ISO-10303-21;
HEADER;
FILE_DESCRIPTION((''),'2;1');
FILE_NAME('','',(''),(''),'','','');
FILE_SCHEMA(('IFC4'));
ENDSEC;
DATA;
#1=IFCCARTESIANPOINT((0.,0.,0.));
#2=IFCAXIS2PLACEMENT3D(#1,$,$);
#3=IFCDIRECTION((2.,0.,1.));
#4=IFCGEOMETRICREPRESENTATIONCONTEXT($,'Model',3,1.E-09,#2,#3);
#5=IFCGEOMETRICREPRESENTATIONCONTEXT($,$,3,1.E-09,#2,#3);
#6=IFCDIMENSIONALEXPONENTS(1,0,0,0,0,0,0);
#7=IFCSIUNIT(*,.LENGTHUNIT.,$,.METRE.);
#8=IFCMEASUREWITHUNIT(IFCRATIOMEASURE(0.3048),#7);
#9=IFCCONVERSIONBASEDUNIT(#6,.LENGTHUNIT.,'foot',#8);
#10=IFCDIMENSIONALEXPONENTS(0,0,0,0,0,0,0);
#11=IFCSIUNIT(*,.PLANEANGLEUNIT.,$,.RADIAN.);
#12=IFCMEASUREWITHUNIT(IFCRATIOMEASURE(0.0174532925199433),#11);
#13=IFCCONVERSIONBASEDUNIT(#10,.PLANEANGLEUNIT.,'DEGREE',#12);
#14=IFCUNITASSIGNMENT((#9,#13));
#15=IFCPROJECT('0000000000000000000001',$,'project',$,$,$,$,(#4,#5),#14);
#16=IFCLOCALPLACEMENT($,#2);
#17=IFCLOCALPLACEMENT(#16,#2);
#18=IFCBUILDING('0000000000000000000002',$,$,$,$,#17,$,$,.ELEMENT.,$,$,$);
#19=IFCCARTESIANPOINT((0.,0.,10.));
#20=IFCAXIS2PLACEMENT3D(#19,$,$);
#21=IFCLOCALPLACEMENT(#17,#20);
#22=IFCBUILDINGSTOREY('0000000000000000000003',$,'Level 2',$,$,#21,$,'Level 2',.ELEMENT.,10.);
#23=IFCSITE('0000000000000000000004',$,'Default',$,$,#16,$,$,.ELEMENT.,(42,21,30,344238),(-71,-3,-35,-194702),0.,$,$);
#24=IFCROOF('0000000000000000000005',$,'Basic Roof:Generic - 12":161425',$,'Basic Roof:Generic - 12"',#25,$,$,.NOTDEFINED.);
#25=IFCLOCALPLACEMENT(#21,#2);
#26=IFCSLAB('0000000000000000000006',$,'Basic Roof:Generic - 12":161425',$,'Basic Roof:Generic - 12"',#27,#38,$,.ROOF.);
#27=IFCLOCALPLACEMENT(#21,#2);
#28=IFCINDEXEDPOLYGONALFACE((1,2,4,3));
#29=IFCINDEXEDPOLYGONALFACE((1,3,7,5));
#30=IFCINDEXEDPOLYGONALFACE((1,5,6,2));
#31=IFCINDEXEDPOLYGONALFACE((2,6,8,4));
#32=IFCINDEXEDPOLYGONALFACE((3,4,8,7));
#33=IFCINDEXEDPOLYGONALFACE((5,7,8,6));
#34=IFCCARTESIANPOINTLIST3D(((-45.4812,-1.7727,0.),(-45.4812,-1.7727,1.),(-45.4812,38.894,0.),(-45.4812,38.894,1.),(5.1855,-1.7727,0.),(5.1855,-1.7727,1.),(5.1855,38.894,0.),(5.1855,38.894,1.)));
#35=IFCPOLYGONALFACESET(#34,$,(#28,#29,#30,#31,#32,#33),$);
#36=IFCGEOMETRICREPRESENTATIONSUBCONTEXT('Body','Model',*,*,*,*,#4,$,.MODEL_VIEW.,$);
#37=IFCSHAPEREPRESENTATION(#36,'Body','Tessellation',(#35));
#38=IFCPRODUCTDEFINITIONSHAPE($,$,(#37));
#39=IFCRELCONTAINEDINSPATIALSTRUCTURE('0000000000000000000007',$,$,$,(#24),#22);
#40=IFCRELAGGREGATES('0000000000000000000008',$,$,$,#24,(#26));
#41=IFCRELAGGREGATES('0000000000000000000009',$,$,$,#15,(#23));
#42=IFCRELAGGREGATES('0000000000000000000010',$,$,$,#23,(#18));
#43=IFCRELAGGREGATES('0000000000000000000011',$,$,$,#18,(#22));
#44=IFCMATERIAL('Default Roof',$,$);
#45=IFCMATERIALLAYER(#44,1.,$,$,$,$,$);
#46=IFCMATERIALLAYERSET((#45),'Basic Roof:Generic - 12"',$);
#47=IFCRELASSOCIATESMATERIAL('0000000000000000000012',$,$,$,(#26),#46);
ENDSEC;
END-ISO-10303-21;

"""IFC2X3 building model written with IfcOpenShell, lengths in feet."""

from ifc_helpers import new_model, entity, si_unit, converted_unit, direction, frame, frame_2d, origin, place, context, subcontext, project, spatial, rectangle, extrude, material, layer, layer_set, element, aggregate, save


model = new_model("IFC2X3")

# Units and contexts
model_context = context("Model", 3, precision=1e-09, world=origin(), true_north=direction((2.0, 0.0, 1.0)))
context_of_model = context(None, 3, precision=1e-09, world=origin(), true_north=direction((2.0, 0.0, 1.0)))
body_context = subcontext(model_context, "Body", "Model", "MODEL_VIEW")
ifc_project = project(units=[converted_unit("LENGTHUNIT", "foot", entity("IfcRatioMeasure", 0.3048), si_unit("LENGTHUNIT", "METRE"), dimensions=[1, 0, 0, 0, 0, 0, 0]), converted_unit("PLANEANGLEUNIT", "DEGREE", entity("IfcRatioMeasure", 0.0174532925199433), si_unit("PLANEANGLEUNIT", "RADIAN"), dimensions=[0, 0, 0, 0, 0, 0, 0])], contexts=[model_context, context_of_model])

# Site, building, storey
site_placement = place(None, origin())
site = spatial("IfcSite", under=ifc_project, at=site_placement, Name="Default", CompositionType="ELEMENT", RefLatitude=(42, 21, 30, 344238), RefLongitude=(-71, -3, -35, -194702), RefElevation=0.0)
building_placement = place(site_placement, origin())
building = spatial("IfcBuilding", under=site, at=building_placement, CompositionType="ELEMENT")
storey_placement = place(building_placement, frame((0.0, 0.0, 10.0)))
storey = spatial("IfcBuildingStorey", under=building, at=storey_placement, Name="Level 2", LongName="Level 2", CompositionType="ELEMENT", Elevation=10.0)

# Roof, slab
roof_placement = place(storey_placement, frame((-45.4812, -1.7727, 0.0)))
roof = element("IfcRoof", 1, at=roof_placement, inside=storey, Name="Basic Roof:Generic - 12\":161425", ObjectType="Basic Roof:Generic - 12\"", ShapeType="NOTDEFINED")
ifc_material = material(Name="Default Roof")
ifc_layer = layer(ifc_material, 1.0)
ifc_layer_set = layer_set([ifc_layer], Name="Basic Roof:Generic - 12\"")
slab_placement = place(roof_placement, origin())
slab = element("IfcSlab", 2, at=slab_placement, material=ifc_layer_set, Name="Basic Roof:Generic - 12\":161425", ObjectType="Basic Roof:Generic - 12\"", PredefinedType="ROOF", context=body_context, shape_type="SweptSolid", body=[
    extrude(rectangle(XDim=50.6667, YDim=40.6667, at=frame_2d((0.0, 0.0), x_axis=(-1.0, 0.0))), frame((25.3333, 20.3333, 0.0)), (0.0, 0.0, 1.0), 1.0),
])
aggregate(roof, [slab])

save(model, "model.ifc")
